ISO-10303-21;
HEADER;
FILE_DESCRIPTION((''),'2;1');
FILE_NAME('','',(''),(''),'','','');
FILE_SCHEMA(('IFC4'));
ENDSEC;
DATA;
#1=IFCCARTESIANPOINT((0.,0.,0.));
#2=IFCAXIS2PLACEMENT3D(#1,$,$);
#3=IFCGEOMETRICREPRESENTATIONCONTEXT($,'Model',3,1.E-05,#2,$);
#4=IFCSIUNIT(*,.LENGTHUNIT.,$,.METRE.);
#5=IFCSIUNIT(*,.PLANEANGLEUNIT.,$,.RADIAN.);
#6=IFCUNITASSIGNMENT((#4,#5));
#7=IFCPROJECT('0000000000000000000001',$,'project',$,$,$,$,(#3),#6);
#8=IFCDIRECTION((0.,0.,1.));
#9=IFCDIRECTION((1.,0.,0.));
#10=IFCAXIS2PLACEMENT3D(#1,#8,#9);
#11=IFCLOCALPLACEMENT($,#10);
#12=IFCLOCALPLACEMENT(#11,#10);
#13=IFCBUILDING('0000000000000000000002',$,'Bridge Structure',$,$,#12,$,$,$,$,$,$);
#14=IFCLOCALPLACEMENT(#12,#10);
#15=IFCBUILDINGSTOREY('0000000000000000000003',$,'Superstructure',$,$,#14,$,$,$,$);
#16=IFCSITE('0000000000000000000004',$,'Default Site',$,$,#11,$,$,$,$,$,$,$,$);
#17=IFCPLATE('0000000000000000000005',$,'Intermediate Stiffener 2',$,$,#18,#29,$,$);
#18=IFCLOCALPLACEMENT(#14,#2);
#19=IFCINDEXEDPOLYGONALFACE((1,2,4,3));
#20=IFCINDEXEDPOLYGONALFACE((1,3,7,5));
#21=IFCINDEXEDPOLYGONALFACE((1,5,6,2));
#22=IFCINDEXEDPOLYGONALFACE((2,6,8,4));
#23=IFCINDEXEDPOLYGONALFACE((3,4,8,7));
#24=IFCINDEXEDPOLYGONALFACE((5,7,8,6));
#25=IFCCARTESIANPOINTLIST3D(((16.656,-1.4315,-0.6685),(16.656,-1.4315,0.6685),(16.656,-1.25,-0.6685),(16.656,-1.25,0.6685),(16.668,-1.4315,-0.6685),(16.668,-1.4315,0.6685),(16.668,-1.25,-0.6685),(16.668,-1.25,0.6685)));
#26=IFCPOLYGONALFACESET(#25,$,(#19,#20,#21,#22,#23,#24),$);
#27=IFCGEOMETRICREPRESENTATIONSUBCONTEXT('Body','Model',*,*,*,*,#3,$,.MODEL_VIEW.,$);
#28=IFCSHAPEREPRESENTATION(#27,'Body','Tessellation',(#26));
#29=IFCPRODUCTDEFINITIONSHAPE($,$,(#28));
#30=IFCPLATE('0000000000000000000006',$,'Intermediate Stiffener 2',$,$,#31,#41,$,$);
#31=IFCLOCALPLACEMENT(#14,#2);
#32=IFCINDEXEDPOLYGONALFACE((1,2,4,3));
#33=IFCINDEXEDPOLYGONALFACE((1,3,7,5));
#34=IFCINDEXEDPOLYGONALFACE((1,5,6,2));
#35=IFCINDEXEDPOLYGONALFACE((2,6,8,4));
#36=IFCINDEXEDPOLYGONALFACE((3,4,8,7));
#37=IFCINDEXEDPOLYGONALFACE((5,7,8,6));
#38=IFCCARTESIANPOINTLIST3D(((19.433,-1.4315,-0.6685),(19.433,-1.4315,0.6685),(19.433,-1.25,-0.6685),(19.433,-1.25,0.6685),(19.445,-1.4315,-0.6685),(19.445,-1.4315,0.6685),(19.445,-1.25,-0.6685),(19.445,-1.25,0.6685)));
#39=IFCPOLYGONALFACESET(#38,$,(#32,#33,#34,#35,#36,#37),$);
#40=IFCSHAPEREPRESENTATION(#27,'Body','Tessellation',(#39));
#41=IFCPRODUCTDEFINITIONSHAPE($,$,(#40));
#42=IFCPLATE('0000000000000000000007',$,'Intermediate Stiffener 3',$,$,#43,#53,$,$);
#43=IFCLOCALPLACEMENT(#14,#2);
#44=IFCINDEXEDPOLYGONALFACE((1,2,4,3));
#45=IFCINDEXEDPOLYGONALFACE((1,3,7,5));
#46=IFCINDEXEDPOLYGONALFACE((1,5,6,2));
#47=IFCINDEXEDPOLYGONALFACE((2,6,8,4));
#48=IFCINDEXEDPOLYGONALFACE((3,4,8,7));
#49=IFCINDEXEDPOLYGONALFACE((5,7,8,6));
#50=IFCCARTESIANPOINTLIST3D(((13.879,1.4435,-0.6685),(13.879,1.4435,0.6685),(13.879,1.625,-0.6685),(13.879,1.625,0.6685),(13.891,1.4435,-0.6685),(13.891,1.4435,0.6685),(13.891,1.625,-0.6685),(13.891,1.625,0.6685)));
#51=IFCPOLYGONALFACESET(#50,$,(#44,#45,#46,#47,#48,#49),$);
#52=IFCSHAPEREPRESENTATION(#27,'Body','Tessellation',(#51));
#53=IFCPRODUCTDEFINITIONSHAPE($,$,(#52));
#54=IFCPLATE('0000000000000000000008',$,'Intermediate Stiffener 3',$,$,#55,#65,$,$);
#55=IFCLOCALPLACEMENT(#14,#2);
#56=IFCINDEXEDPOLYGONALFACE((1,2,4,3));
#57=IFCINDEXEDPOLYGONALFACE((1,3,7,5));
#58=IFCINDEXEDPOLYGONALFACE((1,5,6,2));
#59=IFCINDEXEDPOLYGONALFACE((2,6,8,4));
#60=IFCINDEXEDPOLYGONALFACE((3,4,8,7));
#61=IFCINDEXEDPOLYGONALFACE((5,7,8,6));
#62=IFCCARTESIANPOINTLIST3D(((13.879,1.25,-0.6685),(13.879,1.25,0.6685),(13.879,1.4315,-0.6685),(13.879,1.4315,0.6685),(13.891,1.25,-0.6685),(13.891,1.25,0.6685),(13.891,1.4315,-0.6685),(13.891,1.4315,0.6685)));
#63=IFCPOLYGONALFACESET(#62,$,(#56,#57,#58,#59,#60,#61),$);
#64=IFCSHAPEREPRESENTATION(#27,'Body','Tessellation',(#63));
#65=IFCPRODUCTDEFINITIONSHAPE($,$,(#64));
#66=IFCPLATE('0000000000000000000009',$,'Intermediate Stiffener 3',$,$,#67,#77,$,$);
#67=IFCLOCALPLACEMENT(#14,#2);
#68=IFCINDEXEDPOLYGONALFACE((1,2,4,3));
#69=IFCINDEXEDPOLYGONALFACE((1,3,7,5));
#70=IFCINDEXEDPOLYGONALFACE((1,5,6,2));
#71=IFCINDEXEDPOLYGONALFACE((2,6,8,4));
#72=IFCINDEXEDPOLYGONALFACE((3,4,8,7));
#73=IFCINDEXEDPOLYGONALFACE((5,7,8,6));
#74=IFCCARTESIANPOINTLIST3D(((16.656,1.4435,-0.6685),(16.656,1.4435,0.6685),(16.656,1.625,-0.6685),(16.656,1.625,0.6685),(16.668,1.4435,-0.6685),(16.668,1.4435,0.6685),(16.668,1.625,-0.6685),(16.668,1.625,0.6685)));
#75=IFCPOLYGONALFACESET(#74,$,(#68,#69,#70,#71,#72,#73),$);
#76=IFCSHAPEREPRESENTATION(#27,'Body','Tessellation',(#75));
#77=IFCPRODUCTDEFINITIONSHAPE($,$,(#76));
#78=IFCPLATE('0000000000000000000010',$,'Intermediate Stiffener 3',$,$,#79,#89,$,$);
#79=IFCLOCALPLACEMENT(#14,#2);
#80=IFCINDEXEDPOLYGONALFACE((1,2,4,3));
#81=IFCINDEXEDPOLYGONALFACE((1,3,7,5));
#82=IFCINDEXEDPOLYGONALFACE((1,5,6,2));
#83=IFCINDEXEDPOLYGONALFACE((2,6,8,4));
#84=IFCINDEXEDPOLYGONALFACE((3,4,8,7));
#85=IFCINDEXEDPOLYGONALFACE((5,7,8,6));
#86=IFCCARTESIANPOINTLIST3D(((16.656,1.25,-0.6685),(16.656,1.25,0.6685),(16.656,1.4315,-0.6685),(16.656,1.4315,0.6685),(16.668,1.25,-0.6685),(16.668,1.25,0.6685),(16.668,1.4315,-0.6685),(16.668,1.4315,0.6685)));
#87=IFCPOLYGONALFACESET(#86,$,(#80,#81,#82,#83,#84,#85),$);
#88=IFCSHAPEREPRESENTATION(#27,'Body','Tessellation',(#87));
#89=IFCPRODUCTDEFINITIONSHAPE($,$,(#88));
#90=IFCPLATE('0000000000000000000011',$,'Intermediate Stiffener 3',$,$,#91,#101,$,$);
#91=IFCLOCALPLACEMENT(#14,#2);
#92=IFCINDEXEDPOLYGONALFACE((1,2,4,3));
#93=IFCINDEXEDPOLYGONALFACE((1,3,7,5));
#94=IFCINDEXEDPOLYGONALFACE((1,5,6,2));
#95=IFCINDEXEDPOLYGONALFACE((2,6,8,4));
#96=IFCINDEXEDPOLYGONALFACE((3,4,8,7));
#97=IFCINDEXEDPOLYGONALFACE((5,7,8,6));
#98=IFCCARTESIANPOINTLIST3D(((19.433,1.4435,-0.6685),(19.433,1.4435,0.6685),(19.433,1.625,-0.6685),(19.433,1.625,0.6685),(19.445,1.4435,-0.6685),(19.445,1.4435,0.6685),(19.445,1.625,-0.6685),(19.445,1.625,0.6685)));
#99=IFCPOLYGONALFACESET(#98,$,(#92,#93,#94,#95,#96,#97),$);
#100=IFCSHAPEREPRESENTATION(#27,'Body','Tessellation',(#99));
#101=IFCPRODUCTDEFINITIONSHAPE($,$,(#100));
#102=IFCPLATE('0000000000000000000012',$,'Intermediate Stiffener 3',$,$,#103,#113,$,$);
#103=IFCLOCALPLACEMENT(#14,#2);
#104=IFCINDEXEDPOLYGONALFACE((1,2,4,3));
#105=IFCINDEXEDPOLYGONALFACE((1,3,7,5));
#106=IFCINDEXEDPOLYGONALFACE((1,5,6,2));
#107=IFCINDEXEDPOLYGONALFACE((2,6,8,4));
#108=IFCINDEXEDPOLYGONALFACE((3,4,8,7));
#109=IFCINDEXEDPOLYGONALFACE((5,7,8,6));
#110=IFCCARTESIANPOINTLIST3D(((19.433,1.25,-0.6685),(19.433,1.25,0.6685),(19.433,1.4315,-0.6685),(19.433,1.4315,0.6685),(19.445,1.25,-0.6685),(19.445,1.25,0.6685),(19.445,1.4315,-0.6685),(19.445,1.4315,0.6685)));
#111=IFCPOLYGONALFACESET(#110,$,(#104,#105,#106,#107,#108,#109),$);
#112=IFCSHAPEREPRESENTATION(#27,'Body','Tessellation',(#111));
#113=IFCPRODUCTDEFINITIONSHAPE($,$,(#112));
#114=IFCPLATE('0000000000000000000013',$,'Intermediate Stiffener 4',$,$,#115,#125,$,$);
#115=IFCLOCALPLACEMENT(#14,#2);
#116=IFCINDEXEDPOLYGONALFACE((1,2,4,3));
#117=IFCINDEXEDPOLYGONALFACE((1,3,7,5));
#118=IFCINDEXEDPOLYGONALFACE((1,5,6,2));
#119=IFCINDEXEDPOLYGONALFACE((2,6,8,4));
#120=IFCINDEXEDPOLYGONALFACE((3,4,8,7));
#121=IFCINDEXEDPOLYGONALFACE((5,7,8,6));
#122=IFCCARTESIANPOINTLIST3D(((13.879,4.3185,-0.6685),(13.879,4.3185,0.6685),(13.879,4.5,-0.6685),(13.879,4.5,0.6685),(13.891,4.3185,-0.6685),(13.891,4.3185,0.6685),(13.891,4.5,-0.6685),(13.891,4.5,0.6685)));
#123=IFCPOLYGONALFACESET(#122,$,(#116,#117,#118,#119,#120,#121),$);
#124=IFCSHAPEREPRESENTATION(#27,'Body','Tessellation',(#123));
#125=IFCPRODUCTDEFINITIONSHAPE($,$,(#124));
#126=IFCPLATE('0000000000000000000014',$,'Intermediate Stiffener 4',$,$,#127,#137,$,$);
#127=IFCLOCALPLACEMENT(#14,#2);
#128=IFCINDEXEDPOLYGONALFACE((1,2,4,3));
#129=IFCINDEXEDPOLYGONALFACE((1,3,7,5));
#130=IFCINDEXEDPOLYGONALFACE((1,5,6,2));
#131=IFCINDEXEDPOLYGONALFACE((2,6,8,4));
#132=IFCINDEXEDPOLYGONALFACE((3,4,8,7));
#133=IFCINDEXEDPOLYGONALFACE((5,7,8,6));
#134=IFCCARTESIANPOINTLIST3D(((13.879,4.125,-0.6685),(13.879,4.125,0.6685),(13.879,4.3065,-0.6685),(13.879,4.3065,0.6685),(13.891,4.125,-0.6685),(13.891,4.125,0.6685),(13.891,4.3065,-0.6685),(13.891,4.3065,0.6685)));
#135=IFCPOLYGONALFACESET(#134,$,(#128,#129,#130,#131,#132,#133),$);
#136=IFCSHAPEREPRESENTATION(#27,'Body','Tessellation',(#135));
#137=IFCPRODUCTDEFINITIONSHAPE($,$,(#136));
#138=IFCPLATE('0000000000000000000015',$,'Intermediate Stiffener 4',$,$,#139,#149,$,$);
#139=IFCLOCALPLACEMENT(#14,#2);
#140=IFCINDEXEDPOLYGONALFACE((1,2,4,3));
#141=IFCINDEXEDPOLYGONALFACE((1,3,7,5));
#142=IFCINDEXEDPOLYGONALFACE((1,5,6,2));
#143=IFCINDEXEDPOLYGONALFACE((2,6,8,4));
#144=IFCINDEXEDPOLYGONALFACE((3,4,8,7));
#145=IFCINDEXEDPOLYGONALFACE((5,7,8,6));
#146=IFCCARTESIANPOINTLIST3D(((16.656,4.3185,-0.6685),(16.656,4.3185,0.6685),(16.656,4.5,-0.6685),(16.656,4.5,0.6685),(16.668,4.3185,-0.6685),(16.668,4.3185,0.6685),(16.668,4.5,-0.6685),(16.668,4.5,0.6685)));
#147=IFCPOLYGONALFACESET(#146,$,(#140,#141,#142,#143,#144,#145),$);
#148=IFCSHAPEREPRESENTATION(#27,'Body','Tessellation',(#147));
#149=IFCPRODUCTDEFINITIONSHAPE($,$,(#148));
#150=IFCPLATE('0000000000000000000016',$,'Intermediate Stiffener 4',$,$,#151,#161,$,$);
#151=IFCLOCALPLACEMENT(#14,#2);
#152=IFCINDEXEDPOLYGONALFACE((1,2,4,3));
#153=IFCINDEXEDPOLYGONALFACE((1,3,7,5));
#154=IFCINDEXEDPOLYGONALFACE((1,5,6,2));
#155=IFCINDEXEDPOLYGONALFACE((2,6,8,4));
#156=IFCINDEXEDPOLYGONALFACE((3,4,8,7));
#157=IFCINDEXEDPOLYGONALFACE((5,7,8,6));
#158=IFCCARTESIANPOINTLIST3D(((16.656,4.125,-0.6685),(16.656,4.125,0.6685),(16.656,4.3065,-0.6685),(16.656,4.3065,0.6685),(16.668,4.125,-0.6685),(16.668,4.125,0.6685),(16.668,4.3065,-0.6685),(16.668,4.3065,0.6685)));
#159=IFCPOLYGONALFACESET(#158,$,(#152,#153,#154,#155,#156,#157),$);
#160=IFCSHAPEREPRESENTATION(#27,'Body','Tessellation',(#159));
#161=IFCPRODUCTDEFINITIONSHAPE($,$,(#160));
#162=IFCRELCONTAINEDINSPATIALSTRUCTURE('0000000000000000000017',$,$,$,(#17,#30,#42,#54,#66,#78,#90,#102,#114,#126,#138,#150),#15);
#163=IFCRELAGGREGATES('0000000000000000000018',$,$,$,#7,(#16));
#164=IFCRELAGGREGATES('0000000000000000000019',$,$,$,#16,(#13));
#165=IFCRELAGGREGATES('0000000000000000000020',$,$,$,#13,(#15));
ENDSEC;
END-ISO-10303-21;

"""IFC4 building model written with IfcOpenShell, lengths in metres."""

from ifc_helpers import new_model, si_unit, frame, origin, origin_with_axes, origin_2d_with_axis, place, context, subcontext, project, spatial, rectangle, extrude, element, save


model = new_model("IFC4")

# Units and contexts
model_context = context("Model", 3, precision=1e-05, world=origin())
body_context = subcontext(model_context, "Body", "Model", "MODEL_VIEW")
ifc_project = project(units=[si_unit("LENGTHUNIT", "METRE"), si_unit("PLANEANGLEUNIT", "RADIAN")], contexts=[model_context])

# Site, building, storey
site_placement = place(None, origin_with_axes())
site = spatial("IfcSite", under=ifc_project, at=site_placement, Name="Default Site")
building_placement = place(site_placement, origin_with_axes())
building = spatial("IfcBuilding", under=site, at=building_placement, Name="Bridge Structure")
storey_placement = place(building_placement, origin_with_axes())
storey = spatial("IfcBuildingStorey", under=building, at=storey_placement, Name="Superstructure")

# Plates
for number, where, z_axis, x_axis, name in (
    (1, (16.662, -1.3408, -0.6685), (0.0, 0.0, 1.0), (1.0, 0.0, 0.0), "Intermediate Stiffener 2"),
    (2, (19.439, -1.3408, -0.6685), (0.0, 0.0, 1.0), (1.0, 0.0, 0.0), "Intermediate Stiffener 2"),
    (3, (13.885, 1.5343, -0.6685), (0.0, 0.0, 1.0), (1.0, 0.0, 0.0), "Intermediate Stiffener 3"),
    (4, (13.885, 1.3408, -0.6685), (0.0, 0.0, 1.0), (1.0, 0.0, 0.0), "Intermediate Stiffener 3"),
    (5, (16.662, 1.5343, -0.6685), (0.0, 0.0, 1.0), (1.0, 0.0, 0.0), "Intermediate Stiffener 3"),
    (6, (16.662, 1.3408, -0.6685), (0.0, 0.0, 1.0), (1.0, 0.0, 0.0), "Intermediate Stiffener 3"),
    (7, (19.439, 1.5343, -0.6685), (0.0, 0.0, 1.0), (1.0, 0.0, 0.0), "Intermediate Stiffener 3"),
    (8, (19.439, 1.3408, -0.6685), (0.0, 0.0, 1.0), (1.0, 0.0, 0.0), "Intermediate Stiffener 3"),
    (9, (13.885, 4.4093, -0.6685), (0.0, 0.0, 1.0), (1.0, 0.0, 0.0), "Intermediate Stiffener 4"),
    (10, (13.885, 4.2157, -0.6685), (0.0, 0.0, 1.0), (1.0, 0.0, 0.0), "Intermediate Stiffener 4"),
    (11, (16.662, 4.4093, -0.6685), (0.0, 0.0, 1.0), (1.0, 0.0, 0.0), "Intermediate Stiffener 4"),
    (12, (16.662, 4.2157, -0.6685), (0.0, 0.0, 1.0), (1.0, 0.0, 0.0), "Intermediate Stiffener 4"),
):
    element("IfcPlate", number, at=place(storey_placement, frame(where, z_axis=z_axis, x_axis=x_axis)), inside=storey, Name=name, context=body_context, shape_type="SweptSolid", body=[
        extrude(rectangle(XDim=0.012, YDim=0.1815, at=origin_2d_with_axis()), origin_with_axes(), (0.0, 0.0, 1.0), 1.337),
    ])

save(model, "model.ifc")
